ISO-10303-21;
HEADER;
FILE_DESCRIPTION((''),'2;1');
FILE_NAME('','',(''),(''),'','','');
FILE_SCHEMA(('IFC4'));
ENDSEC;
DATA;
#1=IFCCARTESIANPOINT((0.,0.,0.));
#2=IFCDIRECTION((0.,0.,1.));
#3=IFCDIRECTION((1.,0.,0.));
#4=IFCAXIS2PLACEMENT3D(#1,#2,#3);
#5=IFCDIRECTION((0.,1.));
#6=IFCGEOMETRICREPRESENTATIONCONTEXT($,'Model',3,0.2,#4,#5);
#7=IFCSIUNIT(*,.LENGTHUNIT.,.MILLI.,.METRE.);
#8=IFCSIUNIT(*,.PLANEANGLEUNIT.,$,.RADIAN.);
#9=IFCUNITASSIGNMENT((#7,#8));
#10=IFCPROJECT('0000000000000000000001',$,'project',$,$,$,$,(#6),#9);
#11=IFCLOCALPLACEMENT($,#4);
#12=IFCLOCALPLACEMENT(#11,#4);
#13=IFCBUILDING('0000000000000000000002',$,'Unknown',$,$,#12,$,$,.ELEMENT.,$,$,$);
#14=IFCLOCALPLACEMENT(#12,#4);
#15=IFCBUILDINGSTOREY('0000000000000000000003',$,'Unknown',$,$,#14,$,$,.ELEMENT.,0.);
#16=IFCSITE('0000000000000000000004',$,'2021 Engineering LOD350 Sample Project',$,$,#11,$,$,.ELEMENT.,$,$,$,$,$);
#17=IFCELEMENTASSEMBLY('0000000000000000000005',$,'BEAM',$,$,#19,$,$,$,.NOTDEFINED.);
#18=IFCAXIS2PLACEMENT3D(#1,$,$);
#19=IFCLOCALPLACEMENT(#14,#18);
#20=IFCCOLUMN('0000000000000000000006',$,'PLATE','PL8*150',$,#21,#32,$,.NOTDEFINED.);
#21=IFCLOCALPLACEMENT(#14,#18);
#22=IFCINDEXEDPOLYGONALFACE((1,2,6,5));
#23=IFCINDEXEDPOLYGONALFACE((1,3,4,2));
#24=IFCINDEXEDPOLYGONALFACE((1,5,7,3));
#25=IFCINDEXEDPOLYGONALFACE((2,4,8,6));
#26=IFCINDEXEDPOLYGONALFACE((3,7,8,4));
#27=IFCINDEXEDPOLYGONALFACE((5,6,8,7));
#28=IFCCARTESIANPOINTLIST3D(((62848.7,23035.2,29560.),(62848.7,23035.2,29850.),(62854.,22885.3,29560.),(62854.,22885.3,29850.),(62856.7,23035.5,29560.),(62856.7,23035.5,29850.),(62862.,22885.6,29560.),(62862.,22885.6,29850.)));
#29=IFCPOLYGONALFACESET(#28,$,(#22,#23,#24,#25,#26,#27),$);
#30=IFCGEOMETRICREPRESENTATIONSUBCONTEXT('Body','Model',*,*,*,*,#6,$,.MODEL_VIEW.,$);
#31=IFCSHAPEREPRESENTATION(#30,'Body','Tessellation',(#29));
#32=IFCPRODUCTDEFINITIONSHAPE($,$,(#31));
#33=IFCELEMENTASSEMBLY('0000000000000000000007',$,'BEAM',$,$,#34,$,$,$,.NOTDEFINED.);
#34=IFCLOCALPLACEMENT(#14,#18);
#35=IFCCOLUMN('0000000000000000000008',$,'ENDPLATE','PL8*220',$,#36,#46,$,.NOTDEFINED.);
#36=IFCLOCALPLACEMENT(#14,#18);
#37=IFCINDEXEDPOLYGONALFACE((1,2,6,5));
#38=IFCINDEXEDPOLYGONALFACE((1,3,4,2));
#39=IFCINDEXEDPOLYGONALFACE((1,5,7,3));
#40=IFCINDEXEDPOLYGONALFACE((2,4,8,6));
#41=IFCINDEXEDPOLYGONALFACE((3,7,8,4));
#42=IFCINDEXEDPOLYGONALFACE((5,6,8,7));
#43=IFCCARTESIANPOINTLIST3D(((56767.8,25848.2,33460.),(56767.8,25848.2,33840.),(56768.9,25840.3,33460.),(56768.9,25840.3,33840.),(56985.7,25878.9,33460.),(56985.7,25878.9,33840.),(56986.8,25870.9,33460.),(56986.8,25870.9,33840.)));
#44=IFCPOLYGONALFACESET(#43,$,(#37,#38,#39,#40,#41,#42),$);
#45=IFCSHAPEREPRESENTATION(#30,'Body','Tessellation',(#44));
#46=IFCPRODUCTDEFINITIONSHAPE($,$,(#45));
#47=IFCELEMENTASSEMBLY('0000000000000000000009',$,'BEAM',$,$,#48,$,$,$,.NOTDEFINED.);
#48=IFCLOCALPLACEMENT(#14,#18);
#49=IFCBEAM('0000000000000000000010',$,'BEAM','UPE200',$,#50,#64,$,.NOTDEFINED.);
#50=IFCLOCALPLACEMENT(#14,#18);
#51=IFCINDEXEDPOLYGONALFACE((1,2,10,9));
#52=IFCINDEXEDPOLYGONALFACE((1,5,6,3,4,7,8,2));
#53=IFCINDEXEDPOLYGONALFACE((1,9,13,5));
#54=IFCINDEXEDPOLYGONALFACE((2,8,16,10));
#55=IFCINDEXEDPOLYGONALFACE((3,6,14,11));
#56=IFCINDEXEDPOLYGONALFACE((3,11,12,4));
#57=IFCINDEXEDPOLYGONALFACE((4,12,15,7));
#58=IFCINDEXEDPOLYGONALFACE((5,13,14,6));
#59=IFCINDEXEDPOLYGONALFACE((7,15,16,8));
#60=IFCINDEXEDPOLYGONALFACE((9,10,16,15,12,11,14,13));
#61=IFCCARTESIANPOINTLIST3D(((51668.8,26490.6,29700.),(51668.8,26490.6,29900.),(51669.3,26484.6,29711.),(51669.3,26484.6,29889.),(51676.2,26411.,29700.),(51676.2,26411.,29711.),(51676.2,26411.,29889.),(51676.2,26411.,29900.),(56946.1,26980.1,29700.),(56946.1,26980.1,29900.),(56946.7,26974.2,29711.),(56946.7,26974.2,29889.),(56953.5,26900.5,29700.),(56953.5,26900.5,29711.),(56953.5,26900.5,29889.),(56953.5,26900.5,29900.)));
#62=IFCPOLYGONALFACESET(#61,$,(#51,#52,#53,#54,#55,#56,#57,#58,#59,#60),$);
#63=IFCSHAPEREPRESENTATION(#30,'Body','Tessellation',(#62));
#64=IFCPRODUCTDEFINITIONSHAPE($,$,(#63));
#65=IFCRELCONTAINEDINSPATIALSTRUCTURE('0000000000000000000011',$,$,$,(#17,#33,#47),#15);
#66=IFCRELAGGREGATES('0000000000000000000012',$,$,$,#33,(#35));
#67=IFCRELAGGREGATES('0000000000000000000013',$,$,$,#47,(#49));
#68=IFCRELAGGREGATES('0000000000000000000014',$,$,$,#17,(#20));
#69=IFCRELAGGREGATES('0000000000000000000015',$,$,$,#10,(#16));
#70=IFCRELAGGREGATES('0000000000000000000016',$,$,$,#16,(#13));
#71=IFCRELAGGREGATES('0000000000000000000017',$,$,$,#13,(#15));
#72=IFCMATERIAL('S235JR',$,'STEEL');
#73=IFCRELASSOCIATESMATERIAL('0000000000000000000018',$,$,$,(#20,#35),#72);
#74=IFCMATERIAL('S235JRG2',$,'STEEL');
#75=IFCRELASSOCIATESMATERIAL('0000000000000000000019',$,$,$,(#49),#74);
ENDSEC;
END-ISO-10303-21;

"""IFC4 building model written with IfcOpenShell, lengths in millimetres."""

from ifc_helpers import new_model, si_unit, direction, frame, origin_with_axes, place, context, subcontext, project, spatial, line, indexed_curve, outline, extrude, material, element, aggregate, save


model = new_model("IFC4")

# Units and contexts
model_context = context("Model", 3, precision=0.2, world=origin_with_axes(), true_north=direction((0.0, 1.0)))
body_context = subcontext(model_context, "Body", "Model", "MODEL_VIEW")
ifc_project = project(units=[si_unit("LENGTHUNIT", "METRE", prefix="MILLI"), si_unit("PLANEANGLEUNIT", "RADIAN")], contexts=[model_context])

# Site, building, storey
site_placement = place(None, origin_with_axes())
site = spatial("IfcSite", under=ifc_project, at=site_placement, Name="2021 Engineering LOD350 Sample Project", CompositionType="ELEMENT")
building_placement = place(site_placement, origin_with_axes())
building = spatial("IfcBuilding", under=site, at=building_placement, Name="Unknown", CompositionType="ELEMENT")
storey_placement = place(building_placement, origin_with_axes())
storey = spatial("IfcBuildingStorey", under=building, at=storey_placement, Name="Unknown", CompositionType="ELEMENT", Elevation=0.0)

# Shared definitions
ifc_material_1 = material(Name="S235JR", Category="STEEL")

# Element assembly, column
assembly_1_placement = place(storey_placement, frame((56850.0, 22960.3, 29700.0), z_axis=(0.0, -1.0, 0.0), x_axis=(1.0, 0.0, 0.0)))
assembly_1 = element("IfcElementAssembly", 1, at=assembly_1_placement, inside=storey, Name="BEAM", PredefinedType="NOTDEFINED")
column_1_placement = place(assembly_1_placement, frame((6005.3, -140.0, -0.1), z_axis=(-0.999374, 0.0, 0.03538), x_axis=(0.0, 1.0, 0.0)))
column_1 = element("IfcColumn", 2, at=column_1_placement, material=ifc_material_1, Name="PLATE", Description="PL8*150", PredefinedType="NOTDEFINED", context=body_context, shape_type="SolidModel", body=[
    extrude(outline(indexed_curve([(-4.0, -75.0), (4.0, -75.0), (4.0, 75.0), (-4.0, 75.0)], segments=[line(1, 2, 3, 4, 1)])), frame((0.0, 0.0, 0.0), z_axis=(-1.0, 0.0, 0.0), x_axis=(0.0, 0.0, 1.0)), (0.0, 0.0, -1.0), 290.0),
])

# Element assembly, column
assembly_2_placement = place(storey_placement, frame((56850.0, 18600.0, 33650.0), z_axis=(1.0, 0.0, 0.0), x_axis=(0.0, 1.0, 0.0)))
assembly_2 = element("IfcElementAssembly", 3, at=assembly_2_placement, inside=storey, Name="BEAM", PredefinedType="NOTDEFINED")
column_2_placement = place(assembly_2_placement, frame((7259.6, -190.0, 27.3), z_axis=(-0.990268, 0.0, 0.139173), x_axis=(0.0, 1.0, 0.0)))
column_2 = element("IfcColumn", 4, at=column_2_placement, material=ifc_material_1, Name="ENDPLATE", Description="PL8*220", PredefinedType="NOTDEFINED", context=body_context, shape_type="SolidModel", body=[
    extrude(outline(indexed_curve([(-4.0, -110.0), (4.0, -110.0), (4.0, 110.0), (-4.0, 110.0)], segments=[line(1, 2, 3, 4, 1)])), frame((0.0, 0.0, 0.0), z_axis=(-1.0, 0.0, 0.0), x_axis=(0.0, 0.0, 1.0)), (0.0, 0.0, -1.0), 380.0),
])
aggregate(assembly_2, [column_2])

# Element assembly, beam
assembly_3_placement = place(storey_placement, frame((56949.8, 26940.3, 29800.0), z_axis=(0.092364, -0.995725, 0.0), x_axis=(-0.995725, -0.092364, 0.0)))
assembly_3 = element("IfcElementAssembly", 5, at=assembly_3_placement, inside=storey, Name="BEAM", PredefinedType="NOTDEFINED")
ifc_material_2 = material(Name="S235JRG2", Category="STEEL")
beam_1_placement = place(assembly_3_placement, origin_with_axes())
beam_1 = element("IfcBeam", 6, at=beam_1_placement, material=ifc_material_2, Name="BEAM", Description="UPE200", PredefinedType="NOTDEFINED", context=body_context, shape_type="SolidModel", body=[
    extrude(outline(indexed_curve([(-40.0, -100.0), (40.0, -100.0), (40.0, -89.0), (-34.0, -89.0), (-34.0, 89.0), (40.0, 89.0), (40.0, 100.0), (-40.0, 100.0)], segments=[line(1, 2, 3, 4, 5, 6, 7, 8, 1)])), frame((0.0, 0.0, 0.0), z_axis=(-1.0, 0.0, 0.0), x_axis=(0.0, 0.0, 1.0)), (0.0, 0.0, -1.0), 5300.0),
])
aggregate(assembly_3, [beam_1])

aggregate(assembly_1, [column_1])

save(model, "model.ifc")
